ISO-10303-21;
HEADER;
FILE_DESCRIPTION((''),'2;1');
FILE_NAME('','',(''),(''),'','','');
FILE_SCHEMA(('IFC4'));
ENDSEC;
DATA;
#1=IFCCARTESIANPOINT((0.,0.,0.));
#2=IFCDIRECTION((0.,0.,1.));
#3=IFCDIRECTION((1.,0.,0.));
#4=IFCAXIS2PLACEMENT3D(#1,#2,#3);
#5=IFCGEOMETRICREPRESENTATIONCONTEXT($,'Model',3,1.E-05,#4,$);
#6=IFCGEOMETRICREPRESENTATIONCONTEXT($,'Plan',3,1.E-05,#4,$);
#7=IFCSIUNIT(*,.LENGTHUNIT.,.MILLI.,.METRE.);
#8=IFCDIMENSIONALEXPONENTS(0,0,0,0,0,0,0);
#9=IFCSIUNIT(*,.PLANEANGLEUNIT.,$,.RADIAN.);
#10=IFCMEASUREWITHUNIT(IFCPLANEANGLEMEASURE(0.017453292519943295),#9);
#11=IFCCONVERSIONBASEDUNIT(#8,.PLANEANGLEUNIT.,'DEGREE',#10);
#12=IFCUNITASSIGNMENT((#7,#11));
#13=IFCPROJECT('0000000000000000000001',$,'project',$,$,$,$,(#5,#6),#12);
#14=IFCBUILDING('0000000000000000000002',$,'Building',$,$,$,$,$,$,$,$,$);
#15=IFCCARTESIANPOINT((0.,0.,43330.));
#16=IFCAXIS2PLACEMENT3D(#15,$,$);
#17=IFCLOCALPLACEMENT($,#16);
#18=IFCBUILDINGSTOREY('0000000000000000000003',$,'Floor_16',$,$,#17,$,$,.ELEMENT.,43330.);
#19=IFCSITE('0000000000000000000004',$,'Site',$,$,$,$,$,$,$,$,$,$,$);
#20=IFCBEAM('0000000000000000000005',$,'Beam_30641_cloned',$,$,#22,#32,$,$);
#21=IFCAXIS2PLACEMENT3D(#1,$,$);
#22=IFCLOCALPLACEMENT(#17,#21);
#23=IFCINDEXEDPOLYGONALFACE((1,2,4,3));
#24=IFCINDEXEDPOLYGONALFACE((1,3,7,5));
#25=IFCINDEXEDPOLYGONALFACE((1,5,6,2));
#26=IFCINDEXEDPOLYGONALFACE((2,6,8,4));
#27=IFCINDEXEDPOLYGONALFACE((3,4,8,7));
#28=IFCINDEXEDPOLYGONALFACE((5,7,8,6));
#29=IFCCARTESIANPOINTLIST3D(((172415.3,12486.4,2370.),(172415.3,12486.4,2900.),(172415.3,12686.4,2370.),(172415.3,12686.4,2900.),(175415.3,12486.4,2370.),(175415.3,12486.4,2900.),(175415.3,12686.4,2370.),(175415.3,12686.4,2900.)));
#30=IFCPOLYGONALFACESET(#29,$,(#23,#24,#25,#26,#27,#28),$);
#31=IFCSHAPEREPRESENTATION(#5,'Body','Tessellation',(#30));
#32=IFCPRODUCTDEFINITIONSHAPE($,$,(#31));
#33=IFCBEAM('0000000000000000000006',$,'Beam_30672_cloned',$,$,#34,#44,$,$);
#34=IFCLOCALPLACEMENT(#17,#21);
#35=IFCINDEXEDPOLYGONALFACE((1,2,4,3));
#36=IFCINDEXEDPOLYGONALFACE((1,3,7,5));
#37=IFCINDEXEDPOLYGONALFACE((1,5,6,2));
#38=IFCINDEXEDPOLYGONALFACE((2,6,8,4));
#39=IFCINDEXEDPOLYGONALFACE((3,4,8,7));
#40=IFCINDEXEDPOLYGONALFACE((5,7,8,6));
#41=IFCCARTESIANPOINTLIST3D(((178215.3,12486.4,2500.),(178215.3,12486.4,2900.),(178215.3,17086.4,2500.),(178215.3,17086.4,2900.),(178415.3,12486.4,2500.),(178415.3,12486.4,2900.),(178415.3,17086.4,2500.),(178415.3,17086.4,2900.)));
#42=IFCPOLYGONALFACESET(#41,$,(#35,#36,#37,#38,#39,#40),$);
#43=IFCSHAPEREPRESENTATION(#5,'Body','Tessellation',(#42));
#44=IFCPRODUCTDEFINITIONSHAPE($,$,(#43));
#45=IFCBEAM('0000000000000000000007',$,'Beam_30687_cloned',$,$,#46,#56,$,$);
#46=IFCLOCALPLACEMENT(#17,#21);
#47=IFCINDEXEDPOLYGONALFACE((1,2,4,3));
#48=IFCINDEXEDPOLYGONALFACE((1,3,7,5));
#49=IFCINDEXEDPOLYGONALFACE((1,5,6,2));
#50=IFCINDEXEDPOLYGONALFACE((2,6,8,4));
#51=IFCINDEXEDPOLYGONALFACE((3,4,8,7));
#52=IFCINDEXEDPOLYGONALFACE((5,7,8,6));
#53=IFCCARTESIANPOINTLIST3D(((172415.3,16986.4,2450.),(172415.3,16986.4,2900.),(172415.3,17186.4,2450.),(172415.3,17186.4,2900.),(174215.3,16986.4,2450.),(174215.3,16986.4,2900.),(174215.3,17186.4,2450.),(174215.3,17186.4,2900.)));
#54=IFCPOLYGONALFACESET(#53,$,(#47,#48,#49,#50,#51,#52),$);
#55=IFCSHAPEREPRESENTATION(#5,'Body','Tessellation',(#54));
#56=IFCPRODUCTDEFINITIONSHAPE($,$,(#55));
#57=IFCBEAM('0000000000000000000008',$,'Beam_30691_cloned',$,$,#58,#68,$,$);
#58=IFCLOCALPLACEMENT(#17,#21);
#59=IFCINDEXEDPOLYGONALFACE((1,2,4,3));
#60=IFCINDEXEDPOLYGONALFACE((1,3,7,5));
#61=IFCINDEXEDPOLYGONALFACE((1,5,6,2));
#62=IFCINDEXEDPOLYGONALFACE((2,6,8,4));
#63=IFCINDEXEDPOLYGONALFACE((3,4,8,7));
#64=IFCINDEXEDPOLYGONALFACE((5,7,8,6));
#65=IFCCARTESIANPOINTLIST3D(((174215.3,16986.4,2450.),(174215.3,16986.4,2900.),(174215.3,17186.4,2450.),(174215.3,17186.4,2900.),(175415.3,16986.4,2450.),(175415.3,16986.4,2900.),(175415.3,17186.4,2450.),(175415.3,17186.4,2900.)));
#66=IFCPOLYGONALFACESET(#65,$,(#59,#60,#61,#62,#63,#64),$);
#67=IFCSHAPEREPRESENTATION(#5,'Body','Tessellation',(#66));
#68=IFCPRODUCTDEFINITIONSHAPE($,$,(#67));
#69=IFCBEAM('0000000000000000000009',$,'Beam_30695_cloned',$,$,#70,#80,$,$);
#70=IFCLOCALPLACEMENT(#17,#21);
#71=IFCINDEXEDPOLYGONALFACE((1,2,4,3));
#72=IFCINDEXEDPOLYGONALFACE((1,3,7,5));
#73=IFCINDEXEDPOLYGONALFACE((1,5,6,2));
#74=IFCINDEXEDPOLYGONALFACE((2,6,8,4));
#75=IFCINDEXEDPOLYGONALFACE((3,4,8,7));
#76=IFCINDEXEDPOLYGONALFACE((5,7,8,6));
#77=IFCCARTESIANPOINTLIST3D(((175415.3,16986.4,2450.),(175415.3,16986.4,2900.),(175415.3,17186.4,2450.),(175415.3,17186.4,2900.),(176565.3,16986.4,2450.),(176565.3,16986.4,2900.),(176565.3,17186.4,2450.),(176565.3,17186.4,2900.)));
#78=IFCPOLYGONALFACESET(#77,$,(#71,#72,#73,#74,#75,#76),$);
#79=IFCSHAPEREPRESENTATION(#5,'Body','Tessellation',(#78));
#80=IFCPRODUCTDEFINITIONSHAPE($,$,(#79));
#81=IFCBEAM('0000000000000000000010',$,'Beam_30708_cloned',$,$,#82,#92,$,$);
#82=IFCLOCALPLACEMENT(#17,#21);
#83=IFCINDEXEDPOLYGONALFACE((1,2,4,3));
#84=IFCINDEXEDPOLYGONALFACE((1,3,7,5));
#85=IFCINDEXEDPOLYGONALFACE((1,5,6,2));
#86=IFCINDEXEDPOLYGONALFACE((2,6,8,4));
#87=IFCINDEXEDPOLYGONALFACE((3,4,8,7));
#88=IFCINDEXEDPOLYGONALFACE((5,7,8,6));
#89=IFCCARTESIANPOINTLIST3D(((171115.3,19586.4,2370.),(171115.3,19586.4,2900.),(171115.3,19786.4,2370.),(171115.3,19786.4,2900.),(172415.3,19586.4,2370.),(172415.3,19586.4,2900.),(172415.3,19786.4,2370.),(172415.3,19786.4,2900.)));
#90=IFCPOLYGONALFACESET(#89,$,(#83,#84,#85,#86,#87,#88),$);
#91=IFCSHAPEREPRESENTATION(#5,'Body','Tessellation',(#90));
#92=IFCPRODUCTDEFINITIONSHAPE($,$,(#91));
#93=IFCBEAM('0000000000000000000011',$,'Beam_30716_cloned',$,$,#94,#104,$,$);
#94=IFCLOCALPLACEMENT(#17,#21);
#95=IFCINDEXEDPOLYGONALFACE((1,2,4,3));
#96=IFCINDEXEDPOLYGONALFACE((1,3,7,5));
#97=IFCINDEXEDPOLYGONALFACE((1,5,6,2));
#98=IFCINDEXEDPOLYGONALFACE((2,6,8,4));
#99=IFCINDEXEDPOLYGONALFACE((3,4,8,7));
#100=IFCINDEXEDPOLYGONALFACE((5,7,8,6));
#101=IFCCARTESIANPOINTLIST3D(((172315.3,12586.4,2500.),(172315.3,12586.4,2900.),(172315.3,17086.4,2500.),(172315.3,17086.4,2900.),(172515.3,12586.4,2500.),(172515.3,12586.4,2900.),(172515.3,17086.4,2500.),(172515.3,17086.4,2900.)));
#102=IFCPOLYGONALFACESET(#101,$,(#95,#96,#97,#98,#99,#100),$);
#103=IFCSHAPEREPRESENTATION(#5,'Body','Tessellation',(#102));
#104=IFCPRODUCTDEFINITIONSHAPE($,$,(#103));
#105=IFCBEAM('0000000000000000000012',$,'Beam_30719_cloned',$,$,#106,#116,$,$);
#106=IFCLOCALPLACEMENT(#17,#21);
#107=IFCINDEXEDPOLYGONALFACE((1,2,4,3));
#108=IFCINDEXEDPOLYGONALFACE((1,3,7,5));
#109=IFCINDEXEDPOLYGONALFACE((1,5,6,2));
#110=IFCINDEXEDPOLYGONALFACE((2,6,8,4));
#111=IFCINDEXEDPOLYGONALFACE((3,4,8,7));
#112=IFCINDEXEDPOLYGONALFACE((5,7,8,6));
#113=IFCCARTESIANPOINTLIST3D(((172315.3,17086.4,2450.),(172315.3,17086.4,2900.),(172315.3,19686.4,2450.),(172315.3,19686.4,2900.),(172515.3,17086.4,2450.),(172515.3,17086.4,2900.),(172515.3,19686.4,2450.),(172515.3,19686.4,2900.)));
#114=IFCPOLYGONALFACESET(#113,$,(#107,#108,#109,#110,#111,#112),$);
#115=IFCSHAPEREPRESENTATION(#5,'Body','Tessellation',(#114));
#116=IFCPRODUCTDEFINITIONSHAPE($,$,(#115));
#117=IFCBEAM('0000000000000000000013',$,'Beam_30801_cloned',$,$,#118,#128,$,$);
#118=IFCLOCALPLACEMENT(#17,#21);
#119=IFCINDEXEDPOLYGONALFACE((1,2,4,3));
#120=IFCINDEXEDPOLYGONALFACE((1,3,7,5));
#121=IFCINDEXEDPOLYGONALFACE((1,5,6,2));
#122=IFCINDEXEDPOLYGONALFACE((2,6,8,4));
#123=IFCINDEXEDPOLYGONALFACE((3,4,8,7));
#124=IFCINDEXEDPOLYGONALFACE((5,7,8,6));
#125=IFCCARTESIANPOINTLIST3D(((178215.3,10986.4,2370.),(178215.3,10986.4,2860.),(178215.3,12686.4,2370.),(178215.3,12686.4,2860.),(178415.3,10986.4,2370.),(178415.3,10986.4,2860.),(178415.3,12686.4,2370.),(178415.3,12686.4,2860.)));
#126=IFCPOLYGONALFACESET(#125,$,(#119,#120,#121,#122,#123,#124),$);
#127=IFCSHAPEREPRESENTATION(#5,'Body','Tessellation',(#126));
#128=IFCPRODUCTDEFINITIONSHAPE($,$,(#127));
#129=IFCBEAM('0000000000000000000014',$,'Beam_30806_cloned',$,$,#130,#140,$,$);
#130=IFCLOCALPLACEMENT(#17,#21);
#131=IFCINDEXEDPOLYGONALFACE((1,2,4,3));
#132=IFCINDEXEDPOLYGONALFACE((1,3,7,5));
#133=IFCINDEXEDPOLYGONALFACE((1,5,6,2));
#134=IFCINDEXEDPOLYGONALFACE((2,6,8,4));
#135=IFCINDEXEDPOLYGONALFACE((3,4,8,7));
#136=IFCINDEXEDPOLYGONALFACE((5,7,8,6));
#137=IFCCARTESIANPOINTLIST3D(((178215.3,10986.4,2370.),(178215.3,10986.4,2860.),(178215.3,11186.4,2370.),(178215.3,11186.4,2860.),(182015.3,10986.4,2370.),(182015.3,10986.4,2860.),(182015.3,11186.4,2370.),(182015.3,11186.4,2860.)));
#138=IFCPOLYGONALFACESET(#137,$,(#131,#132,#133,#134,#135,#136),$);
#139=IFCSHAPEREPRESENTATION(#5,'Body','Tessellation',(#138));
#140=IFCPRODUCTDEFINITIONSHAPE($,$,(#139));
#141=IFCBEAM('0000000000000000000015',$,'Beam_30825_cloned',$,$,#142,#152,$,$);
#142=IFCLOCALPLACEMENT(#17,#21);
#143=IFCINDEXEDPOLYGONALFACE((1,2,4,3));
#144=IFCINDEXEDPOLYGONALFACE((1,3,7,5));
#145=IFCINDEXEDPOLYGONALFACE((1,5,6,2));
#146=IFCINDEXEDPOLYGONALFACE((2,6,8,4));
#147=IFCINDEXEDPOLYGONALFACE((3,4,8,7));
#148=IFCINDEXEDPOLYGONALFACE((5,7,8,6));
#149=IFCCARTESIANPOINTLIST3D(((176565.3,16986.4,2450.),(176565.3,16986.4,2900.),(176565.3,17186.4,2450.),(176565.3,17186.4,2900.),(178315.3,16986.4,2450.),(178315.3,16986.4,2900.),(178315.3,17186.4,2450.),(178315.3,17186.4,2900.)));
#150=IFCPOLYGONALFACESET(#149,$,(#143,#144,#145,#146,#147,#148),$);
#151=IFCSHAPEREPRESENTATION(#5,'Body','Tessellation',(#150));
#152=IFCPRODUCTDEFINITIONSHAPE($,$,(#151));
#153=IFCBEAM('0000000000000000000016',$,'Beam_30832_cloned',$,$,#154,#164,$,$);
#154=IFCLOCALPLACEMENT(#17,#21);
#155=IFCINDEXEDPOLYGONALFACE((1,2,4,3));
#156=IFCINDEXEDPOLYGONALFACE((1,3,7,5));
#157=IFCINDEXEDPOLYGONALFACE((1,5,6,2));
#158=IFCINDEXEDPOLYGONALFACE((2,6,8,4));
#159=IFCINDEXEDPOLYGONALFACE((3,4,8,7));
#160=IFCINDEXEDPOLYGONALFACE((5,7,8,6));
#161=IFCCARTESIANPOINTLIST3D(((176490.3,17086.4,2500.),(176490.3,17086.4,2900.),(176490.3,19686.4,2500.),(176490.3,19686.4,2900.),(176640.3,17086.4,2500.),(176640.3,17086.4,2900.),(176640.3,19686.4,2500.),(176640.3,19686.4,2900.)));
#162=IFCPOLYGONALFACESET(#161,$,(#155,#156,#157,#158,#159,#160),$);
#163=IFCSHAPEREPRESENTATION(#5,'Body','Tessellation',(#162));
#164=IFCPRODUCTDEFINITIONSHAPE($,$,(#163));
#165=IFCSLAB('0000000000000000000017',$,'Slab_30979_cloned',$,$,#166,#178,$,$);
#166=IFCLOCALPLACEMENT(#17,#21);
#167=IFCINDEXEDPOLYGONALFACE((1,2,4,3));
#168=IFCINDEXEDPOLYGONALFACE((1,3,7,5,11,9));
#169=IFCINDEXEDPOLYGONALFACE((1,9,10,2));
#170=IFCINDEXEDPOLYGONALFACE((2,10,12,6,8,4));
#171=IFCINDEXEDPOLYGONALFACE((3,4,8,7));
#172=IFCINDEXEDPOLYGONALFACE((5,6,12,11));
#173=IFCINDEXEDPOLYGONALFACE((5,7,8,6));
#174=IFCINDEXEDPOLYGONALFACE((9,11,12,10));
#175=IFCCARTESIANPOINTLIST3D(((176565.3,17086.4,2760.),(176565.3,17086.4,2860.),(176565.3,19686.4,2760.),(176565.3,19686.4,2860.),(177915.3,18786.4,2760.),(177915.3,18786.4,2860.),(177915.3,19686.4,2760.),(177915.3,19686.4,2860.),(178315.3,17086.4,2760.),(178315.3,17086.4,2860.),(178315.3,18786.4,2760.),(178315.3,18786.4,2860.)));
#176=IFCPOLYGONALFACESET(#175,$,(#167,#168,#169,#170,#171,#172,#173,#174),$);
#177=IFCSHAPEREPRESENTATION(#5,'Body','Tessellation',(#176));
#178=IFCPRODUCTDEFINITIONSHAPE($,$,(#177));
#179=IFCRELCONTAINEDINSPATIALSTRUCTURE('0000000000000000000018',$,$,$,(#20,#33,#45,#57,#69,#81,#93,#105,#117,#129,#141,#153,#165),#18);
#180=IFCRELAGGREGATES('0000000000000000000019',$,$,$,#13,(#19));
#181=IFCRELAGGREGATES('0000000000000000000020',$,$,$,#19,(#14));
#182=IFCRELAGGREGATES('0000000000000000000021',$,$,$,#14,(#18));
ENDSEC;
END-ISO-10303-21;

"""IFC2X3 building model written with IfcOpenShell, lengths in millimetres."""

from ifc_helpers import new_model, entity, si_unit, converted_unit, frame, origin_with_axes, origin_2d, place, context, project, spatial, polyline, rectangle, outline, extrude, source, transform, mapped, element, save


model = new_model("IFC2X3")

# Units and contexts
model_context = context("Model", 3, precision=1e-05, world=origin_with_axes())
plan_context = context("Plan", 3, precision=1e-05, world=origin_with_axes())
ifc_project = project(units=[si_unit("LENGTHUNIT", "METRE", prefix="MILLI"), converted_unit("PLANEANGLEUNIT", "DEGREE", entity("IfcPlaneAngleMeasure", 0.017453292519943295), si_unit("PLANEANGLEUNIT", "RADIAN"), dimensions=[0, 0, 0, 0, 0, 0, 0])], contexts=[model_context, plan_context])

# Site, building, storey
site = spatial("IfcSite", under=ifc_project, Name="Site")
building = spatial("IfcBuilding", under=site, Name="Building")
storey_placement = place(None, frame((0.0, 0.0, 43330.0)))
storey = spatial("IfcBuildingStorey", under=building, at=storey_placement, Name="Floor_16", CompositionType="ELEMENT", Elevation=43330.0)

# Beams
shared_shape_1 = source(origin_with_axes(), model_context, "Body", "SweptSolid", [
    extrude(rectangle(XDim=200.0, YDim=530.0, at=origin_2d()), origin_with_axes(), (0.0, 0.0, 1.0), 3000.0),
])
beam_1_placement = place(storey_placement, frame((172415.3, 12586.4, 2635.0), z_axis=(2999.999693, 0.0, 0.0), x_axis=(0.0, -2999.999693, 0.0)))
element("IfcBeam", 1, at=beam_1_placement, inside=storey, Name="Beam_30641_cloned", context=model_context, shape_type="MappedRepresentation", body=[
    mapped(shared_shape_1, transform((0.0, 0.0, 0.0), x_axis=(1.0, 0.0, 0.0), y_axis=(0.0, 1.0, 0.0), z_axis=(0.0, 0.0, 1.0), scale=1.0)),
])
shared_shape_2 = source(origin_with_axes(), model_context, "Body", "SweptSolid", [
    extrude(rectangle(XDim=200.0, YDim=400.0, at=origin_2d()), origin_with_axes(), (0.0, 0.0, 1.0), 4600.0),
])
beam_2_placement = place(storey_placement, frame((178315.3, 12486.4, 2700.0), z_axis=(-0.000341, 4600.030689, 0.0), x_axis=(4600.030689, 0.000341, 0.0)))
element("IfcBeam", 2, at=beam_2_placement, inside=storey, Name="Beam_30672_cloned", context=model_context, shape_type="MappedRepresentation", body=[
    mapped(shared_shape_2, transform((0.0, 0.0, 0.0), x_axis=(1.0, 0.0, 0.0), y_axis=(0.0, 1.0, 0.0), z_axis=(0.0, 0.0, 1.0), scale=1.0)),
])
shared_shape_3 = source(origin_with_axes(), model_context, "Body", "SweptSolid", [
    extrude(rectangle(XDim=200.0, YDim=450.0, at=origin_2d()), origin_with_axes(), (0.0, 0.0, 1.0), 1800.0),
])
beam_3_placement = place(storey_placement, frame((172415.3, 17086.4, 2675.0), z_axis=(1800.000018, -0.000024, 0.0), x_axis=(-0.000024, -1800.000018, 0.0)))
element("IfcBeam", 3, at=beam_3_placement, inside=storey, Name="Beam_30687_cloned", context=model_context, shape_type="MappedRepresentation", body=[
    mapped(shared_shape_3, transform((0.0, 0.0, 0.0), x_axis=(1.0, 0.0, 0.0), y_axis=(0.0, 1.0, 0.0), z_axis=(0.0, 0.0, 1.0), scale=1.0)),
])
shared_shape_4 = source(origin_with_axes(), model_context, "Body", "SweptSolid", [
    extrude(rectangle(XDim=200.0, YDim=450.0, at=origin_2d()), origin_with_axes(), (0.0, 0.0, 1.0), 1200.0),
])
beam_4_placement = place(storey_placement, frame((174215.3, 17086.4, 2675.0), z_axis=(1199.999669, 0.000037, 0.0), x_axis=(0.000037, -1199.999669, 0.0)))
element("IfcBeam", 4, at=beam_4_placement, inside=storey, Name="Beam_30691_cloned", context=model_context, shape_type="MappedRepresentation", body=[
    mapped(shared_shape_4, transform((0.0, 0.0, 0.0), x_axis=(1.0, 0.0, 0.0), y_axis=(0.0, 1.0, 0.0), z_axis=(0.0, 0.0, 1.0), scale=1.0)),
])
shared_shape_5 = source(origin_with_axes(), model_context, "Body", "SweptSolid", [
    extrude(rectangle(XDim=200.0, YDim=450.0, at=origin_2d()), origin_with_axes(), (0.0, 0.0, 1.0), 1150.0),
])
beam_5_placement = place(storey_placement, frame((175415.3, 17086.4, 2675.0), z_axis=(1149.999861, 0.000005, 0.0), x_axis=(0.000005, -1149.999861, 0.0)))
element("IfcBeam", 5, at=beam_5_placement, inside=storey, Name="Beam_30695_cloned", context=model_context, shape_type="MappedRepresentation", body=[
    mapped(shared_shape_5, transform((0.0, 0.0, 0.0), x_axis=(1.0, 0.0, 0.0), y_axis=(0.0, 1.0, 0.0), z_axis=(0.0, 0.0, 1.0), scale=1.0)),
])
shared_shape_6 = source(origin_with_axes(), model_context, "Body", "SweptSolid", [
    extrude(rectangle(XDim=200.0, YDim=530.0, at=origin_2d()), origin_with_axes(), (0.0, 0.0, 1.0), 1300.0),
])
beam_6_placement = place(storey_placement, frame((171115.3, 19686.4, 2635.0), z_axis=(1300.000018, 0.0, 0.0), x_axis=(0.0, -1300.000018, 0.0)))
element("IfcBeam", 6, at=beam_6_placement, inside=storey, Name="Beam_30708_cloned", context=model_context, shape_type="MappedRepresentation", body=[
    mapped(shared_shape_6, transform((0.0, 0.0, 0.0), x_axis=(1.0, 0.0, 0.0), y_axis=(0.0, 1.0, 0.0), z_axis=(0.0, 0.0, 1.0), scale=1.0)),
])
shared_shape_7 = source(origin_with_axes(), model_context, "Body", "SweptSolid", [
    extrude(rectangle(XDim=200.0, YDim=400.0, at=origin_2d()), origin_with_axes(), (0.0, 0.0, 1.0), 4500.0),
])
beam_7_placement = place(storey_placement, frame((172415.3, 12586.4, 2700.0), z_axis=(0.0, 4500.030665, 0.0), x_axis=(4500.030665, 0.0, 0.0)))
element("IfcBeam", 7, at=beam_7_placement, inside=storey, Name="Beam_30716_cloned", context=model_context, shape_type="MappedRepresentation", body=[
    mapped(shared_shape_7, transform((0.0, 0.0, 0.0), x_axis=(1.0, 0.0, 0.0), y_axis=(0.0, 1.0, 0.0), z_axis=(0.0, 0.0, 1.0), scale=1.0)),
])
shared_shape_8 = source(origin_with_axes(), model_context, "Body", "SweptSolid", [
    extrude(rectangle(XDim=200.0, YDim=450.0, at=origin_2d()), origin_with_axes(), (0.0, 0.0, 1.0), 2600.0),
])
beam_8_placement = place(storey_placement, frame((172415.3, 17086.4, 2675.0), z_axis=(0.0, 2599.990188, 0.0), x_axis=(2599.990188, 0.0, 0.0)))
element("IfcBeam", 8, at=beam_8_placement, inside=storey, Name="Beam_30719_cloned", context=model_context, shape_type="MappedRepresentation", body=[
    mapped(shared_shape_8, transform((0.0, 0.0, 0.0), x_axis=(1.0, 0.0, 0.0), y_axis=(0.0, 1.0, 0.0), z_axis=(0.0, 0.0, 1.0), scale=1.0)),
])
shared_shape_9 = source(origin_with_axes(), model_context, "Body", "SweptSolid", [
    extrude(rectangle(XDim=200.0, YDim=490.0, at=origin_2d()), origin_with_axes(), (0.0, 0.0, 1.0), 1700.0),
])
beam_9_placement = place(storey_placement, frame((178315.3, 10986.4, 2615.0), z_axis=(0.0, 1700.0, 0.0), x_axis=(1700.0, 0.0, 0.0)))
element("IfcBeam", 9, at=beam_9_placement, inside=storey, Name="Beam_30801_cloned", context=model_context, shape_type="MappedRepresentation", body=[
    mapped(shared_shape_9, transform((0.0, 0.0, 0.0), x_axis=(1.0, 0.0, 0.0), y_axis=(0.0, 1.0, 0.0), z_axis=(0.0, 0.0, 1.0), scale=1.0)),
])
shared_shape_10 = source(origin_with_axes(), model_context, "Body", "SweptSolid", [
    extrude(rectangle(XDim=200.0, YDim=490.0, at=origin_2d()), origin_with_axes(), (0.0, 0.0, 1.0), 3800.0),
])
beam_10_placement = place(storey_placement, frame((178215.3, 11086.4, 2615.0), z_axis=(3800.00001, 0.0, 0.0), x_axis=(0.0, -3800.00001, 0.0)))
element("IfcBeam", 10, at=beam_10_placement, inside=storey, Name="Beam_30806_cloned", context=model_context, shape_type="MappedRepresentation", body=[
    mapped(shared_shape_10, transform((0.0, 0.0, 0.0), x_axis=(1.0, 0.0, 0.0), y_axis=(0.0, 1.0, 0.0), z_axis=(0.0, 0.0, 1.0), scale=1.0)),
])
shared_shape_11 = source(origin_with_axes(), model_context, "Body", "SweptSolid", [
    extrude(rectangle(XDim=200.0, YDim=450.0, at=origin_2d()), origin_with_axes(), (0.0, 0.0, 1.0), 1750.0),
])
beam_11_placement = place(storey_placement, frame((176565.3, 17086.4, 2675.0), z_axis=(1750.0, 0.000007, 0.0), x_axis=(0.000007, -1750.0, 0.0)))
element("IfcBeam", 11, at=beam_11_placement, inside=storey, Name="Beam_30825_cloned", context=model_context, shape_type="MappedRepresentation", body=[
    mapped(shared_shape_11, transform((0.0, 0.0, 0.0), x_axis=(1.0, 0.0, 0.0), y_axis=(0.0, 1.0, 0.0), z_axis=(0.0, 0.0, 1.0), scale=1.0)),
])
shared_shape_12 = source(origin_with_axes(), model_context, "Body", "SweptSolid", [
    extrude(rectangle(XDim=150.0, YDim=400.0, at=origin_2d()), origin_with_axes(), (0.0, 0.0, 1.0), 2600.0),
])
beam_12_placement = place(storey_placement, frame((176565.3, 17086.4, 2700.0), z_axis=(0.0, 2599.990171, 0.0), x_axis=(2599.990171, 0.0, 0.0)))
element("IfcBeam", 12, at=beam_12_placement, inside=storey, Name="Beam_30832_cloned", context=model_context, shape_type="MappedRepresentation", body=[
    mapped(shared_shape_12, transform((0.0, 0.0, 0.0), x_axis=(1.0, 0.0, 0.0), y_axis=(0.0, 1.0, 0.0), z_axis=(0.0, 0.0, 1.0), scale=1.0)),
])

# Slab
shared_shape_13 = source(origin_with_axes(), model_context, "Body", "SweptSolid", [
    extrude(outline(polyline([(0.0, 0.0), (1350.0, 0.0), (1350.0, 2600.0), (-400.0, 2600.0), (-400.0, 900.0), (0.0, 900.0)])), origin_with_axes(), (0.0, 0.0, 1.0), 100.0),
])
slab_1_placement = place(storey_placement, frame((177915.3, 19686.4, 2760.0), z_axis=(0.0, 0.0, 1.0), x_axis=(-1350.0, 0.0, 0.0)))
element("IfcSlab", 13, at=slab_1_placement, inside=storey, Name="Slab_30979_cloned", context=model_context, shape_type="MappedRepresentation", body=[
    mapped(shared_shape_13, transform((0.0, 0.0, 0.0), x_axis=(1.0, 0.0, 0.0), y_axis=(0.0, 1.0, 0.0), z_axis=(0.0, 0.0, 1.0), scale=1.0)),
])

save(model, "model.ifc")
